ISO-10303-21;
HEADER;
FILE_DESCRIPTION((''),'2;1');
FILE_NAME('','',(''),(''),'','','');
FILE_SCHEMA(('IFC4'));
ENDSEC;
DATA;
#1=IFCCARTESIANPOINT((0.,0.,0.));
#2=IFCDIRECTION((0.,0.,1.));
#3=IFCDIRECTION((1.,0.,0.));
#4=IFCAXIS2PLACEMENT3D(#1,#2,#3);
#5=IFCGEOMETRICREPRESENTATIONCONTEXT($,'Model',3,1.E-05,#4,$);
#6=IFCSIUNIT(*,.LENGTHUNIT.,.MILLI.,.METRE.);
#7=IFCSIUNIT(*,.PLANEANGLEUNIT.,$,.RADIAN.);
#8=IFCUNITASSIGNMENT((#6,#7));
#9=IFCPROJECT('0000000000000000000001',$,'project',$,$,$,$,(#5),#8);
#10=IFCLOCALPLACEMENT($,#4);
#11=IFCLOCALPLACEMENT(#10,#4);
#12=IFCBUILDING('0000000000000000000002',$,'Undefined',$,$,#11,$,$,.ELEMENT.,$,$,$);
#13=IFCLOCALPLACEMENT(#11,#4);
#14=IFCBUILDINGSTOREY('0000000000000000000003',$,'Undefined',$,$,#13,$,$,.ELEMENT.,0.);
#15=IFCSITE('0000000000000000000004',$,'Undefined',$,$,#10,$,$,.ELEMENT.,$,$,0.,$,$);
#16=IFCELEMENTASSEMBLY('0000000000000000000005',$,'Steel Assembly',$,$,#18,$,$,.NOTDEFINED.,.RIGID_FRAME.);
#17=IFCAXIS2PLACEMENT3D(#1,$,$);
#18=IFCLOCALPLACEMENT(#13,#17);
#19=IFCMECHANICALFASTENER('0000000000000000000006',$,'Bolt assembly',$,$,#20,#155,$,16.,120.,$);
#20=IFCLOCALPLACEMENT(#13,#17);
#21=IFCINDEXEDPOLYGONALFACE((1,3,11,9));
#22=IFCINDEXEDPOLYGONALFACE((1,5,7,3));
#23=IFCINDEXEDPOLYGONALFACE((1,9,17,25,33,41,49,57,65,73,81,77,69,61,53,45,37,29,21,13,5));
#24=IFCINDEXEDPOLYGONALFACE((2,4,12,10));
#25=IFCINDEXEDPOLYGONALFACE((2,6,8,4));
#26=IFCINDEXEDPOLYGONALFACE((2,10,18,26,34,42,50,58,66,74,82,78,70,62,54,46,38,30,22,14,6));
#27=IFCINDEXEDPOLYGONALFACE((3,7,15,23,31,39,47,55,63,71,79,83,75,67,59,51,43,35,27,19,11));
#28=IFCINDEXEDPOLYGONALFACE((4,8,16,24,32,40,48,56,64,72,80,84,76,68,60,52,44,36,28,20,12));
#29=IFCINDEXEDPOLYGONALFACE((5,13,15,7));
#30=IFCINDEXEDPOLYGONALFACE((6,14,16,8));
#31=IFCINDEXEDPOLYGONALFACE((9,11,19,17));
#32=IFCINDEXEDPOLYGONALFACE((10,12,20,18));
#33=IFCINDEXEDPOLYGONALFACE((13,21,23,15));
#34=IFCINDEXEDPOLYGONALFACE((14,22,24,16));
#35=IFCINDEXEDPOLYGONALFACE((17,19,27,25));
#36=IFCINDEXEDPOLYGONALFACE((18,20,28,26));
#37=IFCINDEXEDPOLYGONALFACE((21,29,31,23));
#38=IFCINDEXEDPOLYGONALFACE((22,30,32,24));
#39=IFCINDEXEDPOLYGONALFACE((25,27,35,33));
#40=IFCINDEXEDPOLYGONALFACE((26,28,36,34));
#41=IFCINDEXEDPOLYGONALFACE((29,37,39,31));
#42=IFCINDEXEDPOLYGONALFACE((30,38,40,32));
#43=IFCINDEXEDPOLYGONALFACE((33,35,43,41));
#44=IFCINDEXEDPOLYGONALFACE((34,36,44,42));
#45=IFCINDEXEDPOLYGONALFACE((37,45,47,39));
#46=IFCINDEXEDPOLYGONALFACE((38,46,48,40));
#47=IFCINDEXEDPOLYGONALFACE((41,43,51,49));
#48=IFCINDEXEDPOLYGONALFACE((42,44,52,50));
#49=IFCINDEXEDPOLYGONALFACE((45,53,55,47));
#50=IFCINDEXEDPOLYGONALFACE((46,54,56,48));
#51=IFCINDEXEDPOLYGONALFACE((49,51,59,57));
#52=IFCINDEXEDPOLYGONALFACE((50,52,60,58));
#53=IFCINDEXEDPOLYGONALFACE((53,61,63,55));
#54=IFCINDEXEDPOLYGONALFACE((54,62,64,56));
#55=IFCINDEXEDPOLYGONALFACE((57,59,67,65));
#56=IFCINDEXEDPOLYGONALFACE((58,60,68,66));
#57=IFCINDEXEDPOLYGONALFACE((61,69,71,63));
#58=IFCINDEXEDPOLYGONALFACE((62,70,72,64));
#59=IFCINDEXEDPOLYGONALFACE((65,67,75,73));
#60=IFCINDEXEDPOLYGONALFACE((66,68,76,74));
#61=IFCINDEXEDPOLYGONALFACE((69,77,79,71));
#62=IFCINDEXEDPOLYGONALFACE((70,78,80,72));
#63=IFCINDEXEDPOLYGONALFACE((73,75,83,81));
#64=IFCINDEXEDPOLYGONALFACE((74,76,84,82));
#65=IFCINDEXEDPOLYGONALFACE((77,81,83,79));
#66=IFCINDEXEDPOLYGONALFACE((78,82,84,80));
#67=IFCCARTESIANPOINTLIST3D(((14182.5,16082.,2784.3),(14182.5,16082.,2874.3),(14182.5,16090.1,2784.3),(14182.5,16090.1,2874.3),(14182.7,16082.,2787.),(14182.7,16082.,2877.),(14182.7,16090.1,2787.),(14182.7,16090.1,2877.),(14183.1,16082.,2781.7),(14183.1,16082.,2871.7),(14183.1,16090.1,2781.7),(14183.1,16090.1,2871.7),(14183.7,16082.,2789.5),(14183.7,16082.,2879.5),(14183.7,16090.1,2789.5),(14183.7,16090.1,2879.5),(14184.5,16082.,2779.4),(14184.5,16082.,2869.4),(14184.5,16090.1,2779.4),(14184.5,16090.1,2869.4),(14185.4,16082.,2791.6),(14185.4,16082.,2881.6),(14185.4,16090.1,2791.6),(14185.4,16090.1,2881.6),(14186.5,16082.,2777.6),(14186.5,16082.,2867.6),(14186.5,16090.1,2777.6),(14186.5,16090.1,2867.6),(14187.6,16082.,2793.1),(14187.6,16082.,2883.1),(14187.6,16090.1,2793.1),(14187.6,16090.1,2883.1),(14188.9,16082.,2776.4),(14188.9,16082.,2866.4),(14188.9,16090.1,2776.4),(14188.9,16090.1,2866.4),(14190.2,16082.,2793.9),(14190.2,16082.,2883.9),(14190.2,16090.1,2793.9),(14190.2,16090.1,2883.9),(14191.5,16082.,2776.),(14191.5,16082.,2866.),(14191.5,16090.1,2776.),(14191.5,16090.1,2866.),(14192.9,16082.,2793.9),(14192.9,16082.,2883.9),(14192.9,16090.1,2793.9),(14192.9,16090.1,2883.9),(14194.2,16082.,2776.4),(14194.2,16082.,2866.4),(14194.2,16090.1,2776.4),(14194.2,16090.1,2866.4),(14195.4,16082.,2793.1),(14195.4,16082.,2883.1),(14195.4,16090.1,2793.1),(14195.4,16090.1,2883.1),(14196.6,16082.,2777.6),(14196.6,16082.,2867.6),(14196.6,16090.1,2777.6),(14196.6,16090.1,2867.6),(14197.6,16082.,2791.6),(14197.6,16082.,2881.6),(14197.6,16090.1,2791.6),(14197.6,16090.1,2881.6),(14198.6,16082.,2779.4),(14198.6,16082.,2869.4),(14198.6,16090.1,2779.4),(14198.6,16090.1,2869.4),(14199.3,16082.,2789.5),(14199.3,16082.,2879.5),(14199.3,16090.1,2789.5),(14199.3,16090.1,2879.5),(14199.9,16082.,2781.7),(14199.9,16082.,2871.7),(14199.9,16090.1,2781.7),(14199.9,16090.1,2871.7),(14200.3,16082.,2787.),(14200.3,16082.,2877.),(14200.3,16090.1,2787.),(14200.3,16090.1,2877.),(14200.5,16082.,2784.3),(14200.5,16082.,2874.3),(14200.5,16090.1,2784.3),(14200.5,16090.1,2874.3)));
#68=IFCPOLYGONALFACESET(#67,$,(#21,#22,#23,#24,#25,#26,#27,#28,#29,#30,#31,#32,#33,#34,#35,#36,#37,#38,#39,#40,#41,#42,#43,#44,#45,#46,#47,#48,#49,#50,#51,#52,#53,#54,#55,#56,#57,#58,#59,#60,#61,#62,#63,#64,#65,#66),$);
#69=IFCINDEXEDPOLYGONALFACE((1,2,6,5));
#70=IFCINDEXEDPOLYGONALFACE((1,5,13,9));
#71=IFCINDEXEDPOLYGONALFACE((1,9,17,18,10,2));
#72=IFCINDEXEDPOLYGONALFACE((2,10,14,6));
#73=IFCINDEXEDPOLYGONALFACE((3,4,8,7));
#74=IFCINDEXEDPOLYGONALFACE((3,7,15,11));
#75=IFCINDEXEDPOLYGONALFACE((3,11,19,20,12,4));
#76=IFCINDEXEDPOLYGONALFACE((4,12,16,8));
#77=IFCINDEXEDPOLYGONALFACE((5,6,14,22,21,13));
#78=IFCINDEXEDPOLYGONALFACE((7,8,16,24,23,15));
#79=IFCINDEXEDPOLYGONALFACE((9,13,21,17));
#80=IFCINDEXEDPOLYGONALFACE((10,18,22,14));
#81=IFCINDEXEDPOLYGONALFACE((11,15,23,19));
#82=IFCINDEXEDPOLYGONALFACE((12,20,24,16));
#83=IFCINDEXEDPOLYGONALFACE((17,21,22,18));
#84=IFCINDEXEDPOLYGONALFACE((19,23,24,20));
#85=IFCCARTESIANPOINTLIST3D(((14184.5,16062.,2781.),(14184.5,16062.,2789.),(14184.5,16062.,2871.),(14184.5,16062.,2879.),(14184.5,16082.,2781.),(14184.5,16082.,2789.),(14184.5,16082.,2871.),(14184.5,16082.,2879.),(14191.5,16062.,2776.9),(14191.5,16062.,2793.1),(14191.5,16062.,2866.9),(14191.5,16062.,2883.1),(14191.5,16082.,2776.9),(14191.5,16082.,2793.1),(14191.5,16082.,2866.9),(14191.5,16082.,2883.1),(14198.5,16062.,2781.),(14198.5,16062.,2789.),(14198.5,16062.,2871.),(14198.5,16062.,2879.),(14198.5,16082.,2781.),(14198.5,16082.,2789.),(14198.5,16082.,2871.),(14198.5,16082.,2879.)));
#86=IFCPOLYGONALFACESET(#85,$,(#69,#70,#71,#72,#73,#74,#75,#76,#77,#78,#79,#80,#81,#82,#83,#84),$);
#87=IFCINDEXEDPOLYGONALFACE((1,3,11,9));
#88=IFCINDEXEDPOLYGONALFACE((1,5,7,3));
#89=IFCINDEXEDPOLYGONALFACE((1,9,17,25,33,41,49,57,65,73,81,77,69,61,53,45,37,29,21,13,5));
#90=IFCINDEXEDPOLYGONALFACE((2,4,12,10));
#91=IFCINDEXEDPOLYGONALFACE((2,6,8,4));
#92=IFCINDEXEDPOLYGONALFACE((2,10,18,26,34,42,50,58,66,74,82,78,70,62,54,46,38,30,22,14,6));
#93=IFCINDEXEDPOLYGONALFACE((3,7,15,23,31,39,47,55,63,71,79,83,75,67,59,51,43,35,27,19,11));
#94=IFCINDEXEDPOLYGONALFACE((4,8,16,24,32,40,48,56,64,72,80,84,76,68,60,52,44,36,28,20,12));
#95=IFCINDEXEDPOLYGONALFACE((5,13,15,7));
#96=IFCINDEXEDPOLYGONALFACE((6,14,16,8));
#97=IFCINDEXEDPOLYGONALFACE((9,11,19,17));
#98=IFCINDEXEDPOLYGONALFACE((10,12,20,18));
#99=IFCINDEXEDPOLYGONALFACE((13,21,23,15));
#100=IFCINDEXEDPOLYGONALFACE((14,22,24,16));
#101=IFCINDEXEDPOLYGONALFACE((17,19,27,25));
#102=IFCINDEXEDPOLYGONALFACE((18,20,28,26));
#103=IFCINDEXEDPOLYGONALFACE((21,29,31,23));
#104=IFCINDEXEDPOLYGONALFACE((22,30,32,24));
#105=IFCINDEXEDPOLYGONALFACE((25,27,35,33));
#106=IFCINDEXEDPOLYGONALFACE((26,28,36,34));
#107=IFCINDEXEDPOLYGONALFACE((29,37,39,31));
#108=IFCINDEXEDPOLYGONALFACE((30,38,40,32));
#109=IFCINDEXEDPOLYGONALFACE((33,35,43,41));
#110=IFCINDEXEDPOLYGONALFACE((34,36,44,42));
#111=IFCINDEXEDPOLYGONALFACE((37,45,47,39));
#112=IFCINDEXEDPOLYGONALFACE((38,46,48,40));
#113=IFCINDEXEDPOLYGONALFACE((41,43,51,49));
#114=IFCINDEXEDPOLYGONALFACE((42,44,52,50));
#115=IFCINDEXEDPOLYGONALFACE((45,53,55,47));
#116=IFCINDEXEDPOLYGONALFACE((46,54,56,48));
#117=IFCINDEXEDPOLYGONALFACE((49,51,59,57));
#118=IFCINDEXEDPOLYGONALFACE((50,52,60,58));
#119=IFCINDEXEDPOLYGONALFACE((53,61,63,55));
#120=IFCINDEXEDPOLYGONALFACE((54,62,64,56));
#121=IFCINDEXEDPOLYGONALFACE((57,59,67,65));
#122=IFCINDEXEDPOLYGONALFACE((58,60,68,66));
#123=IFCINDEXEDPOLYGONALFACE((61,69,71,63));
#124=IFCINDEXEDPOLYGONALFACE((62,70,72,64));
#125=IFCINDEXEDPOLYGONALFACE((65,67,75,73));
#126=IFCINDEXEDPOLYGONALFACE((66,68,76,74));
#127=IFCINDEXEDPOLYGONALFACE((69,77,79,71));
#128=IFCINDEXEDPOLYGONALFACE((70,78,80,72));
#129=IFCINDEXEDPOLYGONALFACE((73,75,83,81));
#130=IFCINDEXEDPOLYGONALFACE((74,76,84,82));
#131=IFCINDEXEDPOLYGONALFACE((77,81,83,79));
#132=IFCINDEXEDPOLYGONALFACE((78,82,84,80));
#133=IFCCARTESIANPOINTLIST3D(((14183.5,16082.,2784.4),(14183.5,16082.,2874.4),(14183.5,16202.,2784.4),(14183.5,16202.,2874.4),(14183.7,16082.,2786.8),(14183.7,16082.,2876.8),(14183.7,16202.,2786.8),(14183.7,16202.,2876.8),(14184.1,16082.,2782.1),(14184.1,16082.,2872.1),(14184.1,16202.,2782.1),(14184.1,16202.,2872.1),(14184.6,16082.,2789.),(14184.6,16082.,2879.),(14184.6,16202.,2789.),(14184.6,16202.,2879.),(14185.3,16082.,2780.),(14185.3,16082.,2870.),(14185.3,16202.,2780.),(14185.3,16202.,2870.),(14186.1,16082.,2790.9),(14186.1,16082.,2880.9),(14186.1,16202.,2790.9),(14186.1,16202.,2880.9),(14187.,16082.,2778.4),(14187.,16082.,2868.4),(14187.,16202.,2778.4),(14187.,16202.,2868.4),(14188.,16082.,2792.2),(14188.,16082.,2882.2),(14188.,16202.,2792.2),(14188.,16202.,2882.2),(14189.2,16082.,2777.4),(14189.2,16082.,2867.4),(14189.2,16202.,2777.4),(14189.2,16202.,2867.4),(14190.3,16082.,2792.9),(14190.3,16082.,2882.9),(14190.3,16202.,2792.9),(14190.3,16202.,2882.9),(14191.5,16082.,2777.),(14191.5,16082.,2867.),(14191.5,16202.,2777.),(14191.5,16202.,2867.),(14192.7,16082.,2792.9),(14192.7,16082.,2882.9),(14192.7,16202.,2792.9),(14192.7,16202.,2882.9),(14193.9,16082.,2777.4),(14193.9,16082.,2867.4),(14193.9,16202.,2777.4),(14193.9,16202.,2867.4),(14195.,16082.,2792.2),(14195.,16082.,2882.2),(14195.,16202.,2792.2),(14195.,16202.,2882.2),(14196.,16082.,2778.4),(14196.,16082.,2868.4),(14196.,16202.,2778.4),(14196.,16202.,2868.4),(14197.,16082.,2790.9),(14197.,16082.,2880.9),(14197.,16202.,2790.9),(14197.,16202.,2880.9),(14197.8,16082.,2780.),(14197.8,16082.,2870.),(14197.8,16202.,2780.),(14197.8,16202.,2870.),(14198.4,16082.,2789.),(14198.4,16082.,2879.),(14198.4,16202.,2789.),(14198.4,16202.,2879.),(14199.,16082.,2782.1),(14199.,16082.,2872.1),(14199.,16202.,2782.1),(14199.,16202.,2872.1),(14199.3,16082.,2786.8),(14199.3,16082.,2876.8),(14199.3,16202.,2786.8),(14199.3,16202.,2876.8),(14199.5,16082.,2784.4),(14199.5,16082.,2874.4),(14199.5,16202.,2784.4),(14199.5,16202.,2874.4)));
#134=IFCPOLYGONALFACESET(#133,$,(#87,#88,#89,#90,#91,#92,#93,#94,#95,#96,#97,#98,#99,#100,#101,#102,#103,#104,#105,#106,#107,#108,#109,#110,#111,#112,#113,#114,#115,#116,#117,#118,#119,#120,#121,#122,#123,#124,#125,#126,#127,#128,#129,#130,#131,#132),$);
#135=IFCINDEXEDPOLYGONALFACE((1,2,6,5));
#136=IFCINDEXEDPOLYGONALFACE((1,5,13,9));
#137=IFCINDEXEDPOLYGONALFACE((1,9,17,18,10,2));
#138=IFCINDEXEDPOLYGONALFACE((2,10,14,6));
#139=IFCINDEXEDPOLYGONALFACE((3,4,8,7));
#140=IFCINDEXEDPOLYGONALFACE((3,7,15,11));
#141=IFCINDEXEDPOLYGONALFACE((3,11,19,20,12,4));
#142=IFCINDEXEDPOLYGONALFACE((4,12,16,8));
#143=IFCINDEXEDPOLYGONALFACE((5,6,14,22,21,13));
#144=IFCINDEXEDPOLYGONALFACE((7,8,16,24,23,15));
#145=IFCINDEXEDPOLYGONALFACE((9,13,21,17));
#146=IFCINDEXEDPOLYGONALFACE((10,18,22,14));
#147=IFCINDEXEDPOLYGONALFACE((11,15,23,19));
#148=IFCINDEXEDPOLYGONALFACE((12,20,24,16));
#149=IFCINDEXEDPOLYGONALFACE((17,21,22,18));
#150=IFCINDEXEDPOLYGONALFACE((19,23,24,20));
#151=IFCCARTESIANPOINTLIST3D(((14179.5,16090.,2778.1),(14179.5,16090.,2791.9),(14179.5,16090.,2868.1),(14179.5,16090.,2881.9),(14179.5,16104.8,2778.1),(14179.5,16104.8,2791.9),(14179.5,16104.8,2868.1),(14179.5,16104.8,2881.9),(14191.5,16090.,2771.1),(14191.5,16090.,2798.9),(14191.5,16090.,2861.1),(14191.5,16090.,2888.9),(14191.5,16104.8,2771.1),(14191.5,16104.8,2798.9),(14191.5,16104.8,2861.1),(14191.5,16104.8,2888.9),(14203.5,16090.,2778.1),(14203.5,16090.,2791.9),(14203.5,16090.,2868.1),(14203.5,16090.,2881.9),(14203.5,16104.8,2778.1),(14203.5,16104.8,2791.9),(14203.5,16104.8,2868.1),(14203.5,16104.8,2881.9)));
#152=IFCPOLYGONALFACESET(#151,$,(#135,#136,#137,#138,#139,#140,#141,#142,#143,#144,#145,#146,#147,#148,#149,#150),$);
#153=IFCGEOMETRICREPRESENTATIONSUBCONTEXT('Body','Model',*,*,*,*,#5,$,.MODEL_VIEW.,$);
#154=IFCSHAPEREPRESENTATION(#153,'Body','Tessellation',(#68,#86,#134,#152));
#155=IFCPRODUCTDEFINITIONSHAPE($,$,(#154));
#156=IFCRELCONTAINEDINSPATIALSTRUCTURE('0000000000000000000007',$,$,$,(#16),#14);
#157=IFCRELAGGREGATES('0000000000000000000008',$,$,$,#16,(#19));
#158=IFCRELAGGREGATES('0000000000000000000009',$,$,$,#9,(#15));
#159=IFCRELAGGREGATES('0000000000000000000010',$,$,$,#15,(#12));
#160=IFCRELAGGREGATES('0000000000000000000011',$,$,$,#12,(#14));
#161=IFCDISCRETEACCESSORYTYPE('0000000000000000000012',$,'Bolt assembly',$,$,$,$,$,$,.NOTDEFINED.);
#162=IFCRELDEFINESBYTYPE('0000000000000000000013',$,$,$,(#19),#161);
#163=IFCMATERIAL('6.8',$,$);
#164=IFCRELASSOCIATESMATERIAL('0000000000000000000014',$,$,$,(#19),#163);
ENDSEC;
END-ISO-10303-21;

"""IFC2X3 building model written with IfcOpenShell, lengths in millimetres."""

from ifc_helpers import new_model, si_unit, frame, origin_with_axes, origin_2d_with_axis, place, context, subcontext, project, spatial, polyline, circle, outline, extrude, source, transform, mapped, material, type_object, element, aggregate, save


model = new_model("IFC2X3")

# Units and contexts
model_context = context("Model", 3, precision=1e-05, world=origin_with_axes())
body_context = subcontext(model_context, "Body", "Model", "MODEL_VIEW")
ifc_project = project(units=[si_unit("LENGTHUNIT", "METRE", prefix="MILLI"), si_unit("PLANEANGLEUNIT", "RADIAN")], contexts=[model_context])

# Site, building, storey
site_placement = place(None, origin_with_axes())
site = spatial("IfcSite", under=ifc_project, at=site_placement, Name="Undefined", CompositionType="ELEMENT", RefElevation=0.0)
building_placement = place(site_placement, origin_with_axes())
building = spatial("IfcBuilding", under=site, at=building_placement, Name="Undefined", CompositionType="ELEMENT")
storey_placement = place(building_placement, origin_with_axes())
storey = spatial("IfcBuildingStorey", under=building, at=storey_placement, Name="Undefined", CompositionType="ELEMENT", Elevation=0.0)

# Element assembly, mechanical fastener
assembly_1_placement = place(storey_placement, origin_with_axes())
assembly_1 = element("IfcElementAssembly", 1, at=assembly_1_placement, inside=storey, Name="Steel Assembly", AssemblyPlace="NOTDEFINED", PredefinedType="RIGID_FRAME")
ifc_material_1 = material(Name="6.8")
discrete_accessory_type_1 = type_object("IfcDiscreteAccessoryType", Name="Bolt assembly")
shared_shape_1 = source(origin_with_axes(), body_context, "Body", "SweptSolid", [
    extrude(circle(Radius=9.0, at=origin_2d_with_axis()), frame((0.0, -8.0, 0.0), z_axis=(0.0, 1.0, 0.0), x_axis=(1.0, 0.0, 0.0)), (0.0, 0.0, 1.0), 8.1),
    extrude(outline(polyline([(8.1, 0.0), (4.0, 7.0), (-4.0, 7.0), (-8.1, 0.0), (-4.0, -7.0), (4.0, -7.0), (8.1, 0.0)])), frame((0.0, -28.0, 0.0), z_axis=(0.0, 1.0, 0.0), x_axis=(1.0, 0.0, 0.0)), (0.0, 0.0, 1.0), 20.0),
    extrude(circle(Radius=8.0, at=origin_2d_with_axis()), frame((0.0, -8.0, 0.0), z_axis=(0.0, 1.0, 0.0), x_axis=(1.0, 0.0, 0.0)), (0.0, 0.0, 1.0), 120.0),
    extrude(outline(polyline([(13.9, 0.0), (6.9, 12.0), (-6.9, 12.0), (-13.9, 0.0), (-6.9, -12.0), (6.9, -12.0), (13.9, 0.0)])), frame((0.0, 0.0, 0.0), z_axis=(0.0, 1.0, 0.0), x_axis=(1.0, 0.0, 0.0)), (0.0, 0.0, 1.0), 14.8),
])
mechanical_fastener_1_placement = place(assembly_1_placement, frame((14191.5, 16090.0, 2875.0), z_axis=(1.0, 0.0, 0.0), x_axis=(0.0, 0.0, -1.0)))
mechanical_fastener_1 = element("IfcMechanicalFastener", 2, at=mechanical_fastener_1_placement, type_object=discrete_accessory_type_1, material=ifc_material_1, Name="Bolt assembly", NominalDiameter=16.0, NominalLength=120.0, context=body_context, shape_type="MappedRepresentation", body=[
    mapped(shared_shape_1, transform((0.0, 0.0, 0.0))),
    mapped(shared_shape_1, transform((90.0, 0.0, 0.0))),
])

aggregate(assembly_1, [mechanical_fastener_1])

save(model, "model.ifc")
